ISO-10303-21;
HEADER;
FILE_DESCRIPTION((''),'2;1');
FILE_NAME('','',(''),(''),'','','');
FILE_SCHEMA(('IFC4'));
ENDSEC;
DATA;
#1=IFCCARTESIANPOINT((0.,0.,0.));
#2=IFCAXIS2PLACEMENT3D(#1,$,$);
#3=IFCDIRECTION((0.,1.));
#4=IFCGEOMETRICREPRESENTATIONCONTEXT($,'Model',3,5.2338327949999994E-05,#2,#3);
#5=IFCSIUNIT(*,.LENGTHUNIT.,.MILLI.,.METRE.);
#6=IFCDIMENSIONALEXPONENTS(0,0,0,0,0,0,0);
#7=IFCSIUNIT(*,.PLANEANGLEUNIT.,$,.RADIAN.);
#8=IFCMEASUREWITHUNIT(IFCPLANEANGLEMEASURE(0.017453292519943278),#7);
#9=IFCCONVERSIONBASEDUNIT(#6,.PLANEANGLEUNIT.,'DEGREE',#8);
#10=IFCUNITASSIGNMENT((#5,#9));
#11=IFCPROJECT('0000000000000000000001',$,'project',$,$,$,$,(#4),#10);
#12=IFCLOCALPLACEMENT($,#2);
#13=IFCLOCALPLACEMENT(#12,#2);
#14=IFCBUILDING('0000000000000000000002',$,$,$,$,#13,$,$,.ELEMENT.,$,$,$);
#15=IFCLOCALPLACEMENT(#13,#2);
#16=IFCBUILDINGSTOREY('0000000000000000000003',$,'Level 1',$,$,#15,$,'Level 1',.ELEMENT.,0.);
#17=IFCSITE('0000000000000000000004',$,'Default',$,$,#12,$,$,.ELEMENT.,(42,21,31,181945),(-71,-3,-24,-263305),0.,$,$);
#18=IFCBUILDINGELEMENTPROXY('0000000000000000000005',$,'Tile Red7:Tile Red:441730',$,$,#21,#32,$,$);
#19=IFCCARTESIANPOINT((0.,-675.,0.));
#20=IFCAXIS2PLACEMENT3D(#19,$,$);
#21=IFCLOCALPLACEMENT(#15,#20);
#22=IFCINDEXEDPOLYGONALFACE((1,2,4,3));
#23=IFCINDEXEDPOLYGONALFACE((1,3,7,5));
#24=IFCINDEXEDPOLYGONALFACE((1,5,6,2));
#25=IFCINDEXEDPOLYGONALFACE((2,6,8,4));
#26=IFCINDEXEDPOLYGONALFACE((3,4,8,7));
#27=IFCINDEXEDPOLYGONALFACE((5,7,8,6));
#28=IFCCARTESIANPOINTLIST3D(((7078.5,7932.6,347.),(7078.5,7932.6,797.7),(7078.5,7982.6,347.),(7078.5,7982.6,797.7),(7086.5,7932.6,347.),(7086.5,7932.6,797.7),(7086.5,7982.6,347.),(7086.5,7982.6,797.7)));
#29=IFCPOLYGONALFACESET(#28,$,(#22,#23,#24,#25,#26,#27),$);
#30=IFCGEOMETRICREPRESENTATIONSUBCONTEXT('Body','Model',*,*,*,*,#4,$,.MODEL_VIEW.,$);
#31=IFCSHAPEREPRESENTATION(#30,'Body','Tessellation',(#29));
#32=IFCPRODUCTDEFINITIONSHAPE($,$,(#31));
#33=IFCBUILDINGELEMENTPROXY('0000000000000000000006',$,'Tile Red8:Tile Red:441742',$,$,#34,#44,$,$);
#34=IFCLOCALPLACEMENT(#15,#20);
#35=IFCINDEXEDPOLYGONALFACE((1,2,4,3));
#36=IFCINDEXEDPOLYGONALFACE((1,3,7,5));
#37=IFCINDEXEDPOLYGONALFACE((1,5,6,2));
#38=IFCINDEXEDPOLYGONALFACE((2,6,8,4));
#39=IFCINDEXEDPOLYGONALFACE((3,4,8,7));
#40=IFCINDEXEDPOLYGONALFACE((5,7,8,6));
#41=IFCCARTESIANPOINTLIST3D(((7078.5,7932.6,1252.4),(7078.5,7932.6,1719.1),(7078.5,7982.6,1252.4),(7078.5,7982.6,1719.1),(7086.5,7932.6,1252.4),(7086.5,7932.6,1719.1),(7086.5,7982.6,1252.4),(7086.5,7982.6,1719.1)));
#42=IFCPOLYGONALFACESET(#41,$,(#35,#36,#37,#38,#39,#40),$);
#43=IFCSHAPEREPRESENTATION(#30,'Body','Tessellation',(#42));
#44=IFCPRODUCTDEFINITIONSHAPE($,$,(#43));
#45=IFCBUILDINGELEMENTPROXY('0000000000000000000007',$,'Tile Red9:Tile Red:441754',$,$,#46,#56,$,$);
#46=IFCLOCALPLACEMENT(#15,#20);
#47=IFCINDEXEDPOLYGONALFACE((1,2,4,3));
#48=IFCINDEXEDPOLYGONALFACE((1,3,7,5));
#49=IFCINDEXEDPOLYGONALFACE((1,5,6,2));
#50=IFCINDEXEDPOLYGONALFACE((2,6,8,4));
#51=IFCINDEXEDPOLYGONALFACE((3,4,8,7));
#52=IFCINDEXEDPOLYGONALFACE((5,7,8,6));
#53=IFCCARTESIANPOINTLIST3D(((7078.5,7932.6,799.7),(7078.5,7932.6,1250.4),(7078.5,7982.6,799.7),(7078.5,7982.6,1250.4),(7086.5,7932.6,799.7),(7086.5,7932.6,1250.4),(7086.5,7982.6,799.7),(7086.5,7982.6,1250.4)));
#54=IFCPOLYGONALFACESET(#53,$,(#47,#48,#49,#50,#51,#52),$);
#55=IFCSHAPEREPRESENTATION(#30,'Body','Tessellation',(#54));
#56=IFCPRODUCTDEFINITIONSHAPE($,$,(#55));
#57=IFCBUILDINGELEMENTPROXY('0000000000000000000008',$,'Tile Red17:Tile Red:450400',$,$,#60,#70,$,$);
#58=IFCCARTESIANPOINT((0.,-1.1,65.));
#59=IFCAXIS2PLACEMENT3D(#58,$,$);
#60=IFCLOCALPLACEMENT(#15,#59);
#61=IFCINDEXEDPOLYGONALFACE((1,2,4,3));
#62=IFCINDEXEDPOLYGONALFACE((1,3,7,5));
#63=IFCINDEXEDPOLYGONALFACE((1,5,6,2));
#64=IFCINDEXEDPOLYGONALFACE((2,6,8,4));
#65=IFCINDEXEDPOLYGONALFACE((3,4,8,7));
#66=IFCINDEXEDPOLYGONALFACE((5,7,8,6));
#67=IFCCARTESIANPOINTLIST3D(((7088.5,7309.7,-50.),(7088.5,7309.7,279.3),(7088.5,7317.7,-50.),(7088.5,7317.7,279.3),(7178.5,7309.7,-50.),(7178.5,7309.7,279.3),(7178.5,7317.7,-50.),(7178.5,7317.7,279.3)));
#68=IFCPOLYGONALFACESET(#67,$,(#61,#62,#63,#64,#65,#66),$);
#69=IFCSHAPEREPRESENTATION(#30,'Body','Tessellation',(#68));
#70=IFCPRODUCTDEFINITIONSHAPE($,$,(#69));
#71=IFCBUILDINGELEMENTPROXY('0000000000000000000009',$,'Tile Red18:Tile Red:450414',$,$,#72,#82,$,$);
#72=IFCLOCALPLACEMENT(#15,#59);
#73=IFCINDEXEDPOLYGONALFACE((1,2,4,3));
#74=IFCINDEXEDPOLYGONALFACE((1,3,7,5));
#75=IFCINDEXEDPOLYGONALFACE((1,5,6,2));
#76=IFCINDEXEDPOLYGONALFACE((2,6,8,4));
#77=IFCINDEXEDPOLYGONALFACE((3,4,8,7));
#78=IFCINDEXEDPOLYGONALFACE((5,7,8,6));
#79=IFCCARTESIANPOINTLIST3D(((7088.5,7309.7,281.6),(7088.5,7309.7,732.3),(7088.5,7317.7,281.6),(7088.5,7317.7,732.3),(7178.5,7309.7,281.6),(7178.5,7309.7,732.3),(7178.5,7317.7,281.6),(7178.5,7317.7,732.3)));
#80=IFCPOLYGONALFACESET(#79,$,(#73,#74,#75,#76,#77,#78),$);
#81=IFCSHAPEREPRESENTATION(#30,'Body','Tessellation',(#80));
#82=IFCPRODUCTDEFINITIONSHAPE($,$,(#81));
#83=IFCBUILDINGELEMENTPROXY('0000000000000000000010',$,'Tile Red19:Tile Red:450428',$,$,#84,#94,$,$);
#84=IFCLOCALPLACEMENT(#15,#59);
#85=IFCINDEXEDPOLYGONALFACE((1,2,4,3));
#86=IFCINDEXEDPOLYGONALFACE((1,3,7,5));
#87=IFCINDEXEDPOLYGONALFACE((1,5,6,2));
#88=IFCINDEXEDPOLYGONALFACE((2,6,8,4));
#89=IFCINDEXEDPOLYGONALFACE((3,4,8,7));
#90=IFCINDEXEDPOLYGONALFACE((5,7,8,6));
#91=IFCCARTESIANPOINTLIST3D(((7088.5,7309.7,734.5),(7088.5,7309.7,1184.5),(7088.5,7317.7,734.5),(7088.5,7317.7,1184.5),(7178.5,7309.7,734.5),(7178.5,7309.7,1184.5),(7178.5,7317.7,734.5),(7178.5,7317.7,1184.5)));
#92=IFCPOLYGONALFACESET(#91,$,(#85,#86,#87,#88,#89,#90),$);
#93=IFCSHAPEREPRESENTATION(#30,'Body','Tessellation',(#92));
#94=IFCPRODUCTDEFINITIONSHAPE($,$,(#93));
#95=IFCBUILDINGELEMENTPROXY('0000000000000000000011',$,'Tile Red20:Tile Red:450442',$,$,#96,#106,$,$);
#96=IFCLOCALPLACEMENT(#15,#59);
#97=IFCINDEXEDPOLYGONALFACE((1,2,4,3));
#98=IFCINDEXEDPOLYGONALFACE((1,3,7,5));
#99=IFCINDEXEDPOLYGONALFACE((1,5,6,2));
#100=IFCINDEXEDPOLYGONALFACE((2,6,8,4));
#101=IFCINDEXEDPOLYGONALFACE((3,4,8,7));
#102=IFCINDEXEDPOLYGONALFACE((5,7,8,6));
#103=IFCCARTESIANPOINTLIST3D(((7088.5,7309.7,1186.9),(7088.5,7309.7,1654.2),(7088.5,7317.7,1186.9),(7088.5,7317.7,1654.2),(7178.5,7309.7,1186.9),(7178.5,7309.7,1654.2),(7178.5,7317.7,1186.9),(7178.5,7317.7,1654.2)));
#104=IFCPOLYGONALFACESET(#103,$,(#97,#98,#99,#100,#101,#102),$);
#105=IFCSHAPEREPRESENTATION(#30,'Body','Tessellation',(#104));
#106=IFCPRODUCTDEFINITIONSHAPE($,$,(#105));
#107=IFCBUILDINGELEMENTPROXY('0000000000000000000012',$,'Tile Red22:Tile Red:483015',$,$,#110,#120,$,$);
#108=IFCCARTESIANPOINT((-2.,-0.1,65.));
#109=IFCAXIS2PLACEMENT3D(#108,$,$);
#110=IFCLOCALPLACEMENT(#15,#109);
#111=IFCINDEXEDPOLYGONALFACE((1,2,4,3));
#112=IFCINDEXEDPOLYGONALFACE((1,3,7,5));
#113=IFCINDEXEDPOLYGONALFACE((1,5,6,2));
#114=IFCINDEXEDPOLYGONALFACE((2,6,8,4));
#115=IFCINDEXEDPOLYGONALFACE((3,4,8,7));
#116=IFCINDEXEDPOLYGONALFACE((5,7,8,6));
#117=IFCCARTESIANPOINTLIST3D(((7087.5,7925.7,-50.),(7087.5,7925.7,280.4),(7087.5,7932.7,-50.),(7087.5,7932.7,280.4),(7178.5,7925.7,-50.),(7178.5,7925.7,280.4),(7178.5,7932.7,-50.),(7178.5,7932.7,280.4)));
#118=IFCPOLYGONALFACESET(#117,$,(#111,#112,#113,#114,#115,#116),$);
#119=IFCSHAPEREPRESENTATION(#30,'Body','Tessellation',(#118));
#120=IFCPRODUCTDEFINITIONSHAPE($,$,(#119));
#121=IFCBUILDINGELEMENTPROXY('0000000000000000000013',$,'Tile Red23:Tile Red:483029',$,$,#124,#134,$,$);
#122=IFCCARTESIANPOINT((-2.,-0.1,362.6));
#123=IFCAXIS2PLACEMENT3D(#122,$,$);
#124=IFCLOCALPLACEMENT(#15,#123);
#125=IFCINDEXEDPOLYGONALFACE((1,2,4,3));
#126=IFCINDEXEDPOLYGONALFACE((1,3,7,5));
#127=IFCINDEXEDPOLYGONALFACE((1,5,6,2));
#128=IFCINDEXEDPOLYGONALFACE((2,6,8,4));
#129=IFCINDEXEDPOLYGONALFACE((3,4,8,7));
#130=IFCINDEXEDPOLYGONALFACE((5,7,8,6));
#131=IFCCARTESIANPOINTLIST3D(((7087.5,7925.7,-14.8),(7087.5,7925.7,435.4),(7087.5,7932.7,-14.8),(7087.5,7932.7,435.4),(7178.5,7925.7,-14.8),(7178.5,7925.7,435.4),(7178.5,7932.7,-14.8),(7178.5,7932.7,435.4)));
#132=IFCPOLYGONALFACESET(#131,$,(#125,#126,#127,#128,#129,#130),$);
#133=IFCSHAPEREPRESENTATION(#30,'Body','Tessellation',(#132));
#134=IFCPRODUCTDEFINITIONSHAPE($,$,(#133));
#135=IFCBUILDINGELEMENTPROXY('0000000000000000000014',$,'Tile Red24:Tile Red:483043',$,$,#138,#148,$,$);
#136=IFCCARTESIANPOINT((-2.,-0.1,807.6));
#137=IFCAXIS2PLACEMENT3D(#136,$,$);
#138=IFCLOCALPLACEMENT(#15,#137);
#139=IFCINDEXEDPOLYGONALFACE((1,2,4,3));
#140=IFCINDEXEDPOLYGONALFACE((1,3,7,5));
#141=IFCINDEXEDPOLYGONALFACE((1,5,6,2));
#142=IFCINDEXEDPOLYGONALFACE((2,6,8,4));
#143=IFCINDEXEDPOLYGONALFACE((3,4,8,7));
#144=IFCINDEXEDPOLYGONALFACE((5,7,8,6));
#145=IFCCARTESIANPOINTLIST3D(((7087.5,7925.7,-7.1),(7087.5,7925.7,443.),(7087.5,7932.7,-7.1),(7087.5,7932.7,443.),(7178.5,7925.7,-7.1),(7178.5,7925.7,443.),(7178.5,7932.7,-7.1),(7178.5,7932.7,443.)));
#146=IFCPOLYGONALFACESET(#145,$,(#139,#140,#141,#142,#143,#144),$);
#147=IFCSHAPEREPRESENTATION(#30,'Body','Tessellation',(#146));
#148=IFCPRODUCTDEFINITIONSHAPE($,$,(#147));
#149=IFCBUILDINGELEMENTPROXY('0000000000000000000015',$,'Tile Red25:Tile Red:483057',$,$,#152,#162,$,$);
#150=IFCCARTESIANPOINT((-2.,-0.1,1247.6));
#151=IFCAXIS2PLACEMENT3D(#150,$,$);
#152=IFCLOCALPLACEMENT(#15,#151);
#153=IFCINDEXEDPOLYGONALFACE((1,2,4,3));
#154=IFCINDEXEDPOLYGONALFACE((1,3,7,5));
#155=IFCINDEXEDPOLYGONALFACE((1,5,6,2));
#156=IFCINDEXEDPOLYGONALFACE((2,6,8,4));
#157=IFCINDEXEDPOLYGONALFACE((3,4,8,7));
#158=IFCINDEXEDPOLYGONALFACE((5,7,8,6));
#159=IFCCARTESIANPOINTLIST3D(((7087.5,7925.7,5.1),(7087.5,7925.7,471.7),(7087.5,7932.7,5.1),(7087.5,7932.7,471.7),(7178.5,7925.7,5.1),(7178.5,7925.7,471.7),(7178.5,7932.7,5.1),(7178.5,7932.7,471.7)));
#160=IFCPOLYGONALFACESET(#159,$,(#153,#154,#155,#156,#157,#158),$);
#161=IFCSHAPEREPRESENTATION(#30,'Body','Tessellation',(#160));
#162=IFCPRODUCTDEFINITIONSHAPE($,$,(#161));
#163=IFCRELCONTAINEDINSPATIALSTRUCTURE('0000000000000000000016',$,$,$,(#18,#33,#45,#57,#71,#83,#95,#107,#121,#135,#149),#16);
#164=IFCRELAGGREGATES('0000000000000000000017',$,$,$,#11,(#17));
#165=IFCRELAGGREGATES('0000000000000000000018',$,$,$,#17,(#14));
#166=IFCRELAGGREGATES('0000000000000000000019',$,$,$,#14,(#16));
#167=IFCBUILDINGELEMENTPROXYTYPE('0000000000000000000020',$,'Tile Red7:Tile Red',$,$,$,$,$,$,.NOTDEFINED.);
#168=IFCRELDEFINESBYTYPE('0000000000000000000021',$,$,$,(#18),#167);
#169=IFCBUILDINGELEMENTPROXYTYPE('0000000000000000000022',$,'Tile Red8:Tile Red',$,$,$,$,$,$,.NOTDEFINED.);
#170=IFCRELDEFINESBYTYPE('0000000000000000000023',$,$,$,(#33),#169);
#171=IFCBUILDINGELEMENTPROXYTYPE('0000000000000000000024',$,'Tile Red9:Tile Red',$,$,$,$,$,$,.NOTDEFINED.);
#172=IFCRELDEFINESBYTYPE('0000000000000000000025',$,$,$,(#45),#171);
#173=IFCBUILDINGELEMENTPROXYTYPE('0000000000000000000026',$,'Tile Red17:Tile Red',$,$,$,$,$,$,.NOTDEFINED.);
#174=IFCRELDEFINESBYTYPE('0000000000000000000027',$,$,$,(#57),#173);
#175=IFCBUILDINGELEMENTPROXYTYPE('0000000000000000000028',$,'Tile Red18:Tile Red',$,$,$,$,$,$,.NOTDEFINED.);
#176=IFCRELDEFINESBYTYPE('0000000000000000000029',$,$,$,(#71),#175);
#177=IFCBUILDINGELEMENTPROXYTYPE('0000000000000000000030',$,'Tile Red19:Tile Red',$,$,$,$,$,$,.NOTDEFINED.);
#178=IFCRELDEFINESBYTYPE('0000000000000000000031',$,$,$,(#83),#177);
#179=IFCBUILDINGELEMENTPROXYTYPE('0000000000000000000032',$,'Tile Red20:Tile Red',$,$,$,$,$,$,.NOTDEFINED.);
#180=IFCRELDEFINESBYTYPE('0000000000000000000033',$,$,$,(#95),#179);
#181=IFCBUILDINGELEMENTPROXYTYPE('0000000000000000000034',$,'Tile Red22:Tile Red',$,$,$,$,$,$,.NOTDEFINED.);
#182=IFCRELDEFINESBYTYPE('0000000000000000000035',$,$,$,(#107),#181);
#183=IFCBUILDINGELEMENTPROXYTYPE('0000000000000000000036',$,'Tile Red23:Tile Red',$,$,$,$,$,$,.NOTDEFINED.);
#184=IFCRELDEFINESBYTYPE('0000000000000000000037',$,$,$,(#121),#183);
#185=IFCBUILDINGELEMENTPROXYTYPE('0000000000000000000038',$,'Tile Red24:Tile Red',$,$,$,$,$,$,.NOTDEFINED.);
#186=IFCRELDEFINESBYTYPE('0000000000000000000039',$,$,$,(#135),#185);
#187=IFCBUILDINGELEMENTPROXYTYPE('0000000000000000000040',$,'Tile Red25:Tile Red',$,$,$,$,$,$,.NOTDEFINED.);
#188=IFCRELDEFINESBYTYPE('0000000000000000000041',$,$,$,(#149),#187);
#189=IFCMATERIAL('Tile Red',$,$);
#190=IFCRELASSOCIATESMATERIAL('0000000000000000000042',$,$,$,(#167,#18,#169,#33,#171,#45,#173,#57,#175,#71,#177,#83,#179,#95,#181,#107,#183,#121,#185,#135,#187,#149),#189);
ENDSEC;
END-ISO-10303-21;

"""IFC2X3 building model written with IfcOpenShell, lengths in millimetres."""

from ifc_helpers import new_model, entity, si_unit, converted_unit, direction, frame, frame_2d, origin, origin_2d_with_axis, place, context, subcontext, project, spatial, rectangle, extrude, source, transform, mapped, material, type_object, type_shapes, element, save


model = new_model("IFC2X3")

# Units and contexts
model_context = context("Model", 3, precision=5.2338327949999994e-05, world=origin(), true_north=direction((0.0, 1.0)))
body_context = subcontext(model_context, "Body", "Model", "MODEL_VIEW")
ifc_project = project(units=[si_unit("LENGTHUNIT", "METRE", prefix="MILLI"), converted_unit("PLANEANGLEUNIT", "DEGREE", entity("IfcPlaneAngleMeasure", 0.017453292519943278), si_unit("PLANEANGLEUNIT", "RADIAN"), dimensions=[0, 0, 0, 0, 0, 0, 0])], contexts=[model_context])

# Site, building, storey
site_placement = place(None, origin())
site = spatial("IfcSite", under=ifc_project, at=site_placement, Name="Default", CompositionType="ELEMENT", RefLatitude=(42, 21, 31, 181945), RefLongitude=(-71, -3, -24, -263305), RefElevation=0.0)
building_placement = place(site_placement, origin())
building = spatial("IfcBuilding", under=site, at=building_placement, CompositionType="ELEMENT")
storey_placement = place(building_placement, origin())
storey = spatial("IfcBuildingStorey", under=building, at=storey_placement, Name="Level 1", LongName="Level 1", CompositionType="ELEMENT", Elevation=0.0)

# Building element proxies
ifc_material_1 = material(Name="Tile Red")
building_element_proxy_type_1 = type_object("IfcBuildingElementProxyType", Name="Tile Red7:Tile Red", PredefinedType="NOTDEFINED", material=ifc_material_1)
shared_shape_1 = source(origin(), body_context, "Body", "SweptSolid", [
    extrude(rectangle(XDim=8.0, YDim=50.0, at=origin_2d_with_axis()), frame((7082.5, 7957.6, 347.0)), (0.0, 0.0, 1.0), 450.7),
])
type_shapes(building_element_proxy_type_1, [shared_shape_1])
proxy_1_placement = place(storey_placement, frame((0.0, -675.0, 0.0)))
element("IfcBuildingElementProxy", 1, at=proxy_1_placement, inside=storey, type_object=building_element_proxy_type_1, material=ifc_material_1, Name="Tile Red7:Tile Red:441730", context=body_context, shape_type="MappedRepresentation", body=[
    mapped(shared_shape_1, transform((0.0, 0.0, 0.0), scale=1.0)),
])
building_element_proxy_type_2 = type_object("IfcBuildingElementProxyType", Name="Tile Red8:Tile Red", PredefinedType="NOTDEFINED", material=ifc_material_1)
shared_shape_2 = source(origin(), body_context, "Body", "SweptSolid", [
    extrude(rectangle(XDim=8.0, YDim=50.0, at=origin_2d_with_axis()), frame((7082.5, 7957.6, 1252.4)), (0.0, 0.0, 1.0), 466.7),
])
type_shapes(building_element_proxy_type_2, [shared_shape_2])
proxy_2_placement = place(storey_placement, frame((0.0, -675.0, 0.0)))
element("IfcBuildingElementProxy", 2, at=proxy_2_placement, inside=storey, type_object=building_element_proxy_type_2, material=ifc_material_1, Name="Tile Red8:Tile Red:441742", context=body_context, shape_type="MappedRepresentation", body=[
    mapped(shared_shape_2, transform((0.0, 0.0, 0.0), scale=1.0)),
])
building_element_proxy_type_3 = type_object("IfcBuildingElementProxyType", Name="Tile Red9:Tile Red", PredefinedType="NOTDEFINED", material=ifc_material_1)
shared_shape_3 = source(origin(), body_context, "Body", "SweptSolid", [
    extrude(rectangle(XDim=8.0, YDim=50.0, at=origin_2d_with_axis()), frame((7082.5, 7957.6, 799.7)), (0.0, 0.0, 1.0), 450.7),
])
type_shapes(building_element_proxy_type_3, [shared_shape_3])
proxy_3_placement = place(storey_placement, frame((0.0, -675.0, 0.0)))
element("IfcBuildingElementProxy", 3, at=proxy_3_placement, inside=storey, type_object=building_element_proxy_type_3, material=ifc_material_1, Name="Tile Red9:Tile Red:441754", context=body_context, shape_type="MappedRepresentation", body=[
    mapped(shared_shape_3, transform((0.0, 0.0, 0.0), scale=1.0)),
])
building_element_proxy_type_4 = type_object("IfcBuildingElementProxyType", Name="Tile Red17:Tile Red", PredefinedType="NOTDEFINED", material=ifc_material_1)
shared_shape_4 = source(origin(), body_context, "Body", "SweptSolid", [
    extrude(rectangle(XDim=8.0, YDim=90.0, at=frame_2d((0.0, 0.0), x_axis=(1.0, 0.0))), frame((7133.5, 7313.7, -50.0), z_axis=(0.0, 0.0, 1.0), x_axis=(0.0, -1.0, 0.0)), (0.0, 0.0, 1.0), 329.4),
])
type_shapes(building_element_proxy_type_4, [shared_shape_4])
proxy_4_placement = place(storey_placement, frame((0.0, -1.1, 65.0)))
element("IfcBuildingElementProxy", 4, at=proxy_4_placement, inside=storey, type_object=building_element_proxy_type_4, material=ifc_material_1, Name="Tile Red17:Tile Red:450400", context=body_context, shape_type="MappedRepresentation", body=[
    mapped(shared_shape_4, transform((0.0, 0.0, 0.0), scale=1.0)),
])
building_element_proxy_type_5 = type_object("IfcBuildingElementProxyType", Name="Tile Red18:Tile Red", PredefinedType="NOTDEFINED", material=ifc_material_1)
shared_shape_5 = source(origin(), body_context, "Body", "SweptSolid", [
    extrude(rectangle(XDim=8.0, YDim=90.0, at=frame_2d((0.0, 0.0), x_axis=(1.0, 0.0))), frame((7133.5, 7313.7, 281.6), z_axis=(0.0, 0.0, 1.0), x_axis=(0.0, -1.0, 0.0)), (0.0, 0.0, 1.0), 450.8),
])
type_shapes(building_element_proxy_type_5, [shared_shape_5])
proxy_5_placement = place(storey_placement, frame((0.0, -1.1, 65.0)))
element("IfcBuildingElementProxy", 5, at=proxy_5_placement, inside=storey, type_object=building_element_proxy_type_5, material=ifc_material_1, Name="Tile Red18:Tile Red:450414", context=body_context, shape_type="MappedRepresentation", body=[
    mapped(shared_shape_5, transform((0.0, 0.0, 0.0), scale=1.0)),
])
building_element_proxy_type_6 = type_object("IfcBuildingElementProxyType", Name="Tile Red19:Tile Red", PredefinedType="NOTDEFINED", material=ifc_material_1)
shared_shape_6 = source(origin(), body_context, "Body", "SweptSolid", [
    extrude(rectangle(XDim=8.0, YDim=90.0, at=frame_2d((0.0, 0.0), x_axis=(1.0, 0.0))), frame((7133.5, 7313.7, 734.5), z_axis=(0.0, 0.0, 1.0), x_axis=(0.0, -1.0, 0.0)), (0.0, 0.0, 1.0), 450.0),
])
type_shapes(building_element_proxy_type_6, [shared_shape_6])
proxy_6_placement = place(storey_placement, frame((0.0, -1.1, 65.0)))
element("IfcBuildingElementProxy", 6, at=proxy_6_placement, inside=storey, type_object=building_element_proxy_type_6, material=ifc_material_1, Name="Tile Red19:Tile Red:450428", context=body_context, shape_type="MappedRepresentation", body=[
    mapped(shared_shape_6, transform((0.0, 0.0, 0.0), scale=1.0)),
])
building_element_proxy_type_7 = type_object("IfcBuildingElementProxyType", Name="Tile Red20:Tile Red", PredefinedType="NOTDEFINED", material=ifc_material_1)
shared_shape_7 = source(origin(), body_context, "Body", "SweptSolid", [
    extrude(rectangle(XDim=8.0, YDim=90.0, at=frame_2d((0.0, 0.0), x_axis=(1.0, 0.0))), frame((7133.5, 7313.7, 1186.9), z_axis=(0.0, 0.0, 1.0), x_axis=(0.0, -1.0, 0.0)), (0.0, 0.0, 1.0), 467.3),
])
type_shapes(building_element_proxy_type_7, [shared_shape_7])
proxy_7_placement = place(storey_placement, frame((0.0, -1.1, 65.0)))
element("IfcBuildingElementProxy", 7, at=proxy_7_placement, inside=storey, type_object=building_element_proxy_type_7, material=ifc_material_1, Name="Tile Red20:Tile Red:450442", context=body_context, shape_type="MappedRepresentation", body=[
    mapped(shared_shape_7, transform((0.0, 0.0, 0.0), scale=1.0)),
])
building_element_proxy_type_8 = type_object("IfcBuildingElementProxyType", Name="Tile Red22:Tile Red", PredefinedType="NOTDEFINED", material=ifc_material_1)
shared_shape_8 = source(origin(), body_context, "Body", "SweptSolid", [
    extrude(rectangle(XDim=7.0, YDim=91.0, at=frame_2d((0.0, 0.0), x_axis=(1.0, 0.0))), frame((7133.0, 7929.2, -50.0), z_axis=(0.0, 0.0, 1.0), x_axis=(0.0, 1.0, 0.0)), (0.0, 0.0, 1.0), 330.5),
])
type_shapes(building_element_proxy_type_8, [shared_shape_8])
proxy_8_placement = place(storey_placement, frame((-2.0, -0.1, 65.0)))
element("IfcBuildingElementProxy", 8, at=proxy_8_placement, inside=storey, type_object=building_element_proxy_type_8, material=ifc_material_1, Name="Tile Red22:Tile Red:483015", context=body_context, shape_type="MappedRepresentation", body=[
    mapped(shared_shape_8, transform((0.0, 0.0, 0.0), scale=1.0)),
])
building_element_proxy_type_9 = type_object("IfcBuildingElementProxyType", Name="Tile Red23:Tile Red", PredefinedType="NOTDEFINED", material=ifc_material_1)
shared_shape_9 = source(origin(), body_context, "Body", "SweptSolid", [
    extrude(rectangle(XDim=7.0, YDim=91.0, at=frame_2d((0.0, 0.0), x_axis=(1.0, 0.0))), frame((7133.0, 7929.2, -14.8), z_axis=(0.0, 0.0, 1.0), x_axis=(0.0, 1.0, 0.0)), (0.0, 0.0, 1.0), 450.2),
])
type_shapes(building_element_proxy_type_9, [shared_shape_9])
proxy_9_placement = place(storey_placement, frame((-2.0, -0.1, 362.6)))
element("IfcBuildingElementProxy", 9, at=proxy_9_placement, inside=storey, type_object=building_element_proxy_type_9, material=ifc_material_1, Name="Tile Red23:Tile Red:483029", context=body_context, shape_type="MappedRepresentation", body=[
    mapped(shared_shape_9, transform((0.0, 0.0, 0.0), scale=1.0)),
])
building_element_proxy_type_10 = type_object("IfcBuildingElementProxyType", Name="Tile Red24:Tile Red", PredefinedType="NOTDEFINED", material=ifc_material_1)
shared_shape_10 = source(origin(), body_context, "Body", "SweptSolid", [
    extrude(rectangle(XDim=7.0, YDim=91.0, at=frame_2d((0.0, 0.0), x_axis=(1.0, 0.0))), frame((7133.0, 7929.2, -7.1), z_axis=(0.0, 0.0, 1.0), x_axis=(0.0, 1.0, 0.0)), (0.0, 0.0, 1.0), 450.1),
])
type_shapes(building_element_proxy_type_10, [shared_shape_10])
proxy_10_placement = place(storey_placement, frame((-2.0, -0.1, 807.6)))
element("IfcBuildingElementProxy", 10, at=proxy_10_placement, inside=storey, type_object=building_element_proxy_type_10, material=ifc_material_1, Name="Tile Red24:Tile Red:483043", context=body_context, shape_type="MappedRepresentation", body=[
    mapped(shared_shape_10, transform((0.0, 0.0, 0.0), scale=1.0)),
])
building_element_proxy_type_11 = type_object("IfcBuildingElementProxyType", Name="Tile Red25:Tile Red", PredefinedType="NOTDEFINED", material=ifc_material_1)
shared_shape_11 = source(origin(), body_context, "Body", "SweptSolid", [
    extrude(rectangle(XDim=7.0, YDim=91.0, at=frame_2d((0.0, 0.0), x_axis=(1.0, 0.0))), frame((7133.0, 7929.2, 5.1), z_axis=(0.0, 0.0, 1.0), x_axis=(0.0, 1.0, 0.0)), (0.0, 0.0, 1.0), 466.6),
])
type_shapes(building_element_proxy_type_11, [shared_shape_11])
proxy_11_placement = place(storey_placement, frame((-2.0, -0.1, 1247.6)))
element("IfcBuildingElementProxy", 11, at=proxy_11_placement, inside=storey, type_object=building_element_proxy_type_11, material=ifc_material_1, Name="Tile Red25:Tile Red:483057", context=body_context, shape_type="MappedRepresentation", body=[
    mapped(shared_shape_11, transform((0.0, 0.0, 0.0), scale=1.0)),
])

save(model, "model.ifc")
